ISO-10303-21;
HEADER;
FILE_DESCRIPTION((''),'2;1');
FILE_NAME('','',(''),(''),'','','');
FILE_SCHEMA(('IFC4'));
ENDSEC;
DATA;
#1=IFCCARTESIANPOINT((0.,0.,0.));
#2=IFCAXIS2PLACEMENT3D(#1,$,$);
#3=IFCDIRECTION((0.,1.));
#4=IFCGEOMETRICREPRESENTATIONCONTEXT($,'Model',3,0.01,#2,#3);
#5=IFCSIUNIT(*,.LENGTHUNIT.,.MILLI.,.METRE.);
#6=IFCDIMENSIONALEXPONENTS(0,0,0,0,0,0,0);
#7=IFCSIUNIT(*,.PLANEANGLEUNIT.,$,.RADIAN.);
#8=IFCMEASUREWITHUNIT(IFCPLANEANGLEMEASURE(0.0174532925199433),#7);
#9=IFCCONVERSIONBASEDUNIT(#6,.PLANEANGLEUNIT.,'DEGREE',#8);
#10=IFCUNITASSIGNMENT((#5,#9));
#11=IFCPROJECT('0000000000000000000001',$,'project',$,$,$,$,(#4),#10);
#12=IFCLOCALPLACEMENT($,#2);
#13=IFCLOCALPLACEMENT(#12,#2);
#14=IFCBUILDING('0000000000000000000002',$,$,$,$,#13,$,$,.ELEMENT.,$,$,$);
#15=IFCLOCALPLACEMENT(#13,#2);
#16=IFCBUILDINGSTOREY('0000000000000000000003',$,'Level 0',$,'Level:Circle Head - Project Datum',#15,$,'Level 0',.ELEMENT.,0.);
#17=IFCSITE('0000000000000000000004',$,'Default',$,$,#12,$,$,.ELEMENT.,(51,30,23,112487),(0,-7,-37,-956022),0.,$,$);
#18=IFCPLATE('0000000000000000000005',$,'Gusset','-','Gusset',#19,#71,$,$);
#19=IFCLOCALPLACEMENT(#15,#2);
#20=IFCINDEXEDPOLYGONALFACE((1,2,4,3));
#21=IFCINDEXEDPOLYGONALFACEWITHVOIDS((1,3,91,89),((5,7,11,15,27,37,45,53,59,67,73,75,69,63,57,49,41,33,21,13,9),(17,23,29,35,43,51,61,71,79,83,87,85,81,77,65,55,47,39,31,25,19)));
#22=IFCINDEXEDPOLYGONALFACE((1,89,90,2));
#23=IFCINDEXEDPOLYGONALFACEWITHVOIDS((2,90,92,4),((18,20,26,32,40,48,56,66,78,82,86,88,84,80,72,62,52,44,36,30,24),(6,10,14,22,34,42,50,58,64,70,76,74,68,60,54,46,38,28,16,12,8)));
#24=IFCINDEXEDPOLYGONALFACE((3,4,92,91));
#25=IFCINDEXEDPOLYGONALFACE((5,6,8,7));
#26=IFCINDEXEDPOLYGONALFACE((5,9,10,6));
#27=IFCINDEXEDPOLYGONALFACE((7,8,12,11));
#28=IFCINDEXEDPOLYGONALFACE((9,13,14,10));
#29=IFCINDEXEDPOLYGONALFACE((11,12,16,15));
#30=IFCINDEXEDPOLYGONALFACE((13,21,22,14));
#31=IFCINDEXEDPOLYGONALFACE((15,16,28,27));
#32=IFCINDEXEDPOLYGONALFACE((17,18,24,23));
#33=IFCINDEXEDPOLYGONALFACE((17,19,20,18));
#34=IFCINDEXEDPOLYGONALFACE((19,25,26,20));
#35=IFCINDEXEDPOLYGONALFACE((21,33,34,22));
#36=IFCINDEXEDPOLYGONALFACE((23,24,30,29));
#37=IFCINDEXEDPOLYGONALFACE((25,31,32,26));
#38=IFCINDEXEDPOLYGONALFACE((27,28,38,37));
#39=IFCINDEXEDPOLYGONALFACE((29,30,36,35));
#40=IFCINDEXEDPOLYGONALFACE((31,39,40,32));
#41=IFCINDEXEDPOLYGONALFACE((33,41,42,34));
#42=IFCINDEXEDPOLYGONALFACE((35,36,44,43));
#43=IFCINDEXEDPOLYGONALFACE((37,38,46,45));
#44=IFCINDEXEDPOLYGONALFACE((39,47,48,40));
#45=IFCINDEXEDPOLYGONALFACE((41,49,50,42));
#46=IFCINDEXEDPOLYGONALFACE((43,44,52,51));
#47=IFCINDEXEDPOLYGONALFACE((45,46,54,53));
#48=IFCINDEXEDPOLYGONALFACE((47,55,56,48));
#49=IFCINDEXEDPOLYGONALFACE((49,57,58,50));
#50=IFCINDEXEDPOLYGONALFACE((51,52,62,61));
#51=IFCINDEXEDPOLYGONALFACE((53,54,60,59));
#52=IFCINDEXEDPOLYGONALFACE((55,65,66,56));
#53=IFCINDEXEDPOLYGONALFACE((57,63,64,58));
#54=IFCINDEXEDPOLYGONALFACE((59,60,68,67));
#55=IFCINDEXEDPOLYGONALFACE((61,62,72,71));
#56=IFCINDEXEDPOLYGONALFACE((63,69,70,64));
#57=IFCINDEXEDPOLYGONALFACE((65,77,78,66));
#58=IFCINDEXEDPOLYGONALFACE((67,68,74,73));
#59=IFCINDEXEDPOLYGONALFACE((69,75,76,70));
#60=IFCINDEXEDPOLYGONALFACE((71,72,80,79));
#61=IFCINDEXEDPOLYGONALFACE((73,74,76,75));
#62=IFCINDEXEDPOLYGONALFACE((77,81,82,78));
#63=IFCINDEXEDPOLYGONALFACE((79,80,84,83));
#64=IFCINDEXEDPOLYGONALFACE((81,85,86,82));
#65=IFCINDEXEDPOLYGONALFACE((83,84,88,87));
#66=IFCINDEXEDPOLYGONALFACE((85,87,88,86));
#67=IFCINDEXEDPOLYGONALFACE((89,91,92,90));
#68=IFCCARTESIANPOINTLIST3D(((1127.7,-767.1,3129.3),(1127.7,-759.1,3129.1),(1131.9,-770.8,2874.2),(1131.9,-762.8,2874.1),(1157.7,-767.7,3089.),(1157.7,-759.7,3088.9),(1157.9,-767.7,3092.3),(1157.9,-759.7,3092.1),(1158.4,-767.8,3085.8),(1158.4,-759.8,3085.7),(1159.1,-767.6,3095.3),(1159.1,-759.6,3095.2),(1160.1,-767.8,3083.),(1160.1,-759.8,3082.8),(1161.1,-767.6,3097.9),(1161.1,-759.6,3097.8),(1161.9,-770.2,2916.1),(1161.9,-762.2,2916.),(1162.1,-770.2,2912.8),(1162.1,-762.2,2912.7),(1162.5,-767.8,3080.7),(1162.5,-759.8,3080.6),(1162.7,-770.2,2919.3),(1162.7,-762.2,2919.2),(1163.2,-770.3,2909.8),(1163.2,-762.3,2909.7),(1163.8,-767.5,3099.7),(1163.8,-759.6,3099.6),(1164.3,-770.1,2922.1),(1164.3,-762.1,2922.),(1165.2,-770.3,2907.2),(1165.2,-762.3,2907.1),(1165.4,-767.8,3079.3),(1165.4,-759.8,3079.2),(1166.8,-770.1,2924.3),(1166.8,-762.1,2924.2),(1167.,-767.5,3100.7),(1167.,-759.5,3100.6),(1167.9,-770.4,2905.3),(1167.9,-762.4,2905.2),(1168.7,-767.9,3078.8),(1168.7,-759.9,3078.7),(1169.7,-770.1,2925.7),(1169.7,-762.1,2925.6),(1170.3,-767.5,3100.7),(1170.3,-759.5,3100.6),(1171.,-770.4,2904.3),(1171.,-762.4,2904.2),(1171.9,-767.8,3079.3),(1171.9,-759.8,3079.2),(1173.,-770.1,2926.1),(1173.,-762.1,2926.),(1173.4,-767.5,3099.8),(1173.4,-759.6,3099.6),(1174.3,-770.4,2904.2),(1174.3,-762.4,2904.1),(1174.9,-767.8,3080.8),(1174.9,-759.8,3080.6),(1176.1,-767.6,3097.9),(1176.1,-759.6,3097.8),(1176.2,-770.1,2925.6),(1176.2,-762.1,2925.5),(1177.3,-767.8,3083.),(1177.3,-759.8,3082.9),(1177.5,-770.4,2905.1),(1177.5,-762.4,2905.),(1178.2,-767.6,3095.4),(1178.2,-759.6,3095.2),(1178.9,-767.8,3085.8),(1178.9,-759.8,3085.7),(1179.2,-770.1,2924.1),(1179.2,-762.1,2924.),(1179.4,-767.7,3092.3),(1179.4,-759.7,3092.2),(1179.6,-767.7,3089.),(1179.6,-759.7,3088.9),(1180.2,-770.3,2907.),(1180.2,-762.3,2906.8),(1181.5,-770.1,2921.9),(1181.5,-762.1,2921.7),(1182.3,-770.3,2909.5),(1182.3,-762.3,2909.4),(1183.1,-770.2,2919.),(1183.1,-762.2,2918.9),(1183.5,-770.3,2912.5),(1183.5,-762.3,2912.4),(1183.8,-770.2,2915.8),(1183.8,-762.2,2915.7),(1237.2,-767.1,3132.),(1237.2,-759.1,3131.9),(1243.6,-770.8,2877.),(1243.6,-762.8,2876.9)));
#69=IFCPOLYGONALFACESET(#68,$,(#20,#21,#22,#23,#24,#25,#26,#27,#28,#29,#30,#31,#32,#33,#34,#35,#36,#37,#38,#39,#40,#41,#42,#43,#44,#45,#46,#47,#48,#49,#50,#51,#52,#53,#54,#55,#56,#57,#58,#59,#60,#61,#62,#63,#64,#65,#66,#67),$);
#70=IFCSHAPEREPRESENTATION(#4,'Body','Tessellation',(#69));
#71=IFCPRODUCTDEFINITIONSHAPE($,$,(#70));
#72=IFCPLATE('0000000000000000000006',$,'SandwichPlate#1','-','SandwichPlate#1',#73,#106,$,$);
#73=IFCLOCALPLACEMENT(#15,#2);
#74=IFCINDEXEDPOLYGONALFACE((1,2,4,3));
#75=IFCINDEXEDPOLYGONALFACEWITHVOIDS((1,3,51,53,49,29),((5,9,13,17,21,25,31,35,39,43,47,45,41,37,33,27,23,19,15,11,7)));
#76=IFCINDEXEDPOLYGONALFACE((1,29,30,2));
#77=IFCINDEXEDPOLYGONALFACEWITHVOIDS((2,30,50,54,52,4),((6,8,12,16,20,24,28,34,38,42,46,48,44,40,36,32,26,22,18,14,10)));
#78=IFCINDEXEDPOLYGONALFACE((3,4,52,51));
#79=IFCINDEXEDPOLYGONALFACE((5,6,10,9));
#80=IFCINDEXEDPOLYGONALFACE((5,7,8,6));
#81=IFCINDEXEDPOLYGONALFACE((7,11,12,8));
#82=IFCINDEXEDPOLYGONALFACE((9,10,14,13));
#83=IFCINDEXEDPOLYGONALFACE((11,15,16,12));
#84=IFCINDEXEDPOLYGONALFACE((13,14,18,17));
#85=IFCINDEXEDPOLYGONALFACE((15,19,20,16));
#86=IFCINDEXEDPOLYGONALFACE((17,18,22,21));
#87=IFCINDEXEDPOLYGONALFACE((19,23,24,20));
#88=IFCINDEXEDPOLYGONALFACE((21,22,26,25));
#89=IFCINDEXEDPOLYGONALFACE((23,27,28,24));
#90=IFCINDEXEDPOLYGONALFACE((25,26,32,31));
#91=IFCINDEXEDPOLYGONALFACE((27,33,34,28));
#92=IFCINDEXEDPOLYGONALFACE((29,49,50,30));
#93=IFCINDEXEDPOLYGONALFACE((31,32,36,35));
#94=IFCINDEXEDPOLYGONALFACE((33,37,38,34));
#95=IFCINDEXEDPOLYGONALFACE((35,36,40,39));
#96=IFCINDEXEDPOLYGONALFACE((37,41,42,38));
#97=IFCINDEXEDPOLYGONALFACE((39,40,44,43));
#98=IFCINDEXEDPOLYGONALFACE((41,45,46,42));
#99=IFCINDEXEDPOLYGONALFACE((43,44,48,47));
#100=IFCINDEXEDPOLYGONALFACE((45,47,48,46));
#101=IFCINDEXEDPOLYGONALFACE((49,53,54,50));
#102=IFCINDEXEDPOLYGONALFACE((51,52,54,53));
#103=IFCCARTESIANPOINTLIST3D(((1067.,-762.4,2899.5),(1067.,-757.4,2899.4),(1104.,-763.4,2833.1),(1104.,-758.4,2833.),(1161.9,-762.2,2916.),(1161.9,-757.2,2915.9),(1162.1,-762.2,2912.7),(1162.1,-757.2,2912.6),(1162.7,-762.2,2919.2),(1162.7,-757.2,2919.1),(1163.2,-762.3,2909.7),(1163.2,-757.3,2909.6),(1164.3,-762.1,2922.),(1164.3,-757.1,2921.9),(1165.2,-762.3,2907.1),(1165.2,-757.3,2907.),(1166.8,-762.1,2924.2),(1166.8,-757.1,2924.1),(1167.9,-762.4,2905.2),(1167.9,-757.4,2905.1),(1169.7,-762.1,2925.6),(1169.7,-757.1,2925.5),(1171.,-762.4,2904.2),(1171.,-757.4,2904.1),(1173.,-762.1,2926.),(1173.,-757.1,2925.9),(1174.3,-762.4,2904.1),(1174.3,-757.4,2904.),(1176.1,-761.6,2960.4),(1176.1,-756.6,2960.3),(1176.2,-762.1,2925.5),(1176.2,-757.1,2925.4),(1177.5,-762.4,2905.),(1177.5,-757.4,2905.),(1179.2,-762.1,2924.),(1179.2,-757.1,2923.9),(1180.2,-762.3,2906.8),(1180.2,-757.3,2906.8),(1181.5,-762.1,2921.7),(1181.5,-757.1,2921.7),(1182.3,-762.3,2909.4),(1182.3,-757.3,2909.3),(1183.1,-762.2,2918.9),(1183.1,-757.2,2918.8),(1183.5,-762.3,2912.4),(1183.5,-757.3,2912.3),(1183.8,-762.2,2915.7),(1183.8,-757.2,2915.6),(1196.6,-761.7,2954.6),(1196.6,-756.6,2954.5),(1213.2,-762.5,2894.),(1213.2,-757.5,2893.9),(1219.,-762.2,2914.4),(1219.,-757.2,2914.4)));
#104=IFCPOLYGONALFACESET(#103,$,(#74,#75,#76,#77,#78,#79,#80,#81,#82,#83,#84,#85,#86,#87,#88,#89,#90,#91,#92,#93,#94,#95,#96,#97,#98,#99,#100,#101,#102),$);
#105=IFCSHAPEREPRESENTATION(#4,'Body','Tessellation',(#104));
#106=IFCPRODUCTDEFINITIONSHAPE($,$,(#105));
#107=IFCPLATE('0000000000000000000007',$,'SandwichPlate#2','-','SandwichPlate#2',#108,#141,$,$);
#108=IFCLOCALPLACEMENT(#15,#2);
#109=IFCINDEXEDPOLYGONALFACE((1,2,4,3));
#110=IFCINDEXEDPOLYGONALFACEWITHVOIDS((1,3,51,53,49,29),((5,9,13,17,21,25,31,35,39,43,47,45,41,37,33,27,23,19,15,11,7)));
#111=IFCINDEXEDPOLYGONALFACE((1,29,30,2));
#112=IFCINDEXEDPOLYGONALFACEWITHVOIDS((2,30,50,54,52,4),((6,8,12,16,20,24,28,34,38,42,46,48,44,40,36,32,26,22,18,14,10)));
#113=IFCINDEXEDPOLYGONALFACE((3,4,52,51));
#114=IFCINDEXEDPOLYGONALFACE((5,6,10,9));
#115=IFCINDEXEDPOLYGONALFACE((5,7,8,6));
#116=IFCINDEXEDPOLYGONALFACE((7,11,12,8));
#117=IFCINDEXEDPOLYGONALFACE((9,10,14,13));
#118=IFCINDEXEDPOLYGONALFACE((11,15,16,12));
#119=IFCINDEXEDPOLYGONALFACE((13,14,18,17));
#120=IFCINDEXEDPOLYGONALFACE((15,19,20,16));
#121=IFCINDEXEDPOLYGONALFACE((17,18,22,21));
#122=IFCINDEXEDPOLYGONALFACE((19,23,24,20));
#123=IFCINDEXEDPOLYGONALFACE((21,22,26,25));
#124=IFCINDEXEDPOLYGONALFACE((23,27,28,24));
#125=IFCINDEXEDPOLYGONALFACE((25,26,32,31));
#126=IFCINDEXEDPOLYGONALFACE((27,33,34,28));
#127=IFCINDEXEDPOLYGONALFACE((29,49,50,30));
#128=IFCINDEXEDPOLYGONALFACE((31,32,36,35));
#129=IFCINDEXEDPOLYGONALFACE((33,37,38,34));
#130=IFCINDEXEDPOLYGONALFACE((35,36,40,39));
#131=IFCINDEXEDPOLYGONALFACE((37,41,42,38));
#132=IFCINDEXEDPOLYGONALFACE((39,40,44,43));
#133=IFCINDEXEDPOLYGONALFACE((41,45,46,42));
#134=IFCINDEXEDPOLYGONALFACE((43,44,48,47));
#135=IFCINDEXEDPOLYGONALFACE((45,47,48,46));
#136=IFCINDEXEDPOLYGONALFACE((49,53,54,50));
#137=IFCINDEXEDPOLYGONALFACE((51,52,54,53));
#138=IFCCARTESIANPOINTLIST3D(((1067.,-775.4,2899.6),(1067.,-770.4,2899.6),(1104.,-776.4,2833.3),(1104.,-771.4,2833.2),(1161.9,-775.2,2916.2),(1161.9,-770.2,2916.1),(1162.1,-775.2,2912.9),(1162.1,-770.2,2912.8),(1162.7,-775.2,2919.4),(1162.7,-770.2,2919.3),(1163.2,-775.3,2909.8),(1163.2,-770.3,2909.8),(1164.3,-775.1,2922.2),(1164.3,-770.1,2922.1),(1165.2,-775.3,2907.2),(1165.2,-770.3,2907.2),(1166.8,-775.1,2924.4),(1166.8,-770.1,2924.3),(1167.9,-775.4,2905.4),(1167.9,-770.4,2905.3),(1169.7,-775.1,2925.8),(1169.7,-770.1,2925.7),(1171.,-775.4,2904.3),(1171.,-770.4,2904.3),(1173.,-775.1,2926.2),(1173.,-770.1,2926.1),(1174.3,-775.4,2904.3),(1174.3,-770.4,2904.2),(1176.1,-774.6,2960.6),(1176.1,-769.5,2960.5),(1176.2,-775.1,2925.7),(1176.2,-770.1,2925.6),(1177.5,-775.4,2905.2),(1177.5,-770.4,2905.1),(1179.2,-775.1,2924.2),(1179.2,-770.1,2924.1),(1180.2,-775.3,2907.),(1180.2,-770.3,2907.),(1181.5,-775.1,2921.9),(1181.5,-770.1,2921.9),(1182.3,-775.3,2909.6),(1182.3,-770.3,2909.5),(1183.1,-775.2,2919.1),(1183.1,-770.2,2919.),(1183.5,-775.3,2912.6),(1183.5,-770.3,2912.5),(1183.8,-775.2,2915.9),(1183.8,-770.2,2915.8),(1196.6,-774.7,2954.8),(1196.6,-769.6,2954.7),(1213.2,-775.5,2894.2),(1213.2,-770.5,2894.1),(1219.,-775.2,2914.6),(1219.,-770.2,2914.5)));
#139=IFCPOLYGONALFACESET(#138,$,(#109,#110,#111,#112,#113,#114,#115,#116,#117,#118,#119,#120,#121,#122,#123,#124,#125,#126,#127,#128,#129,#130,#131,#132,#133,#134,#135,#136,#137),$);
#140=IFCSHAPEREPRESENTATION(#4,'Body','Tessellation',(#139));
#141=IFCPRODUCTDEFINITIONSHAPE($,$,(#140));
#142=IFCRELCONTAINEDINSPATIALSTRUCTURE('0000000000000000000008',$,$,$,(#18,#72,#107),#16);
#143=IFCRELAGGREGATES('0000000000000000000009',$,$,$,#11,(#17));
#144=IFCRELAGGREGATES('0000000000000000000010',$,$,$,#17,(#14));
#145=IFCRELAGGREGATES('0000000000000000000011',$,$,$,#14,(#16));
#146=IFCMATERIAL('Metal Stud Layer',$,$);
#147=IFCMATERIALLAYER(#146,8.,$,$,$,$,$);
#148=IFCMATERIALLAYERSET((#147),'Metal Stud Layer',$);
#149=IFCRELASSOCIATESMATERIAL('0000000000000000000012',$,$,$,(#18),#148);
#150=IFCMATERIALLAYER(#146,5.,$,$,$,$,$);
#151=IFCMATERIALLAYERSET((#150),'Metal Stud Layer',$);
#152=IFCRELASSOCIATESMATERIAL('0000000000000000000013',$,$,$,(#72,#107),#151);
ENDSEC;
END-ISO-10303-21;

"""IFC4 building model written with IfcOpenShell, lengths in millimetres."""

from ifc_helpers import new_model, entity, si_unit, converted_unit, direction, frame, origin, origin_with_axes, origin_2d_with_axis, place, context, project, spatial, polyline, circle, outline, extrude, material, layer, layer_set, element, save


model = new_model("IFC4")

# Units and contexts
model_context = context("Model", 3, precision=0.01, world=origin(), true_north=direction((0.0, 1.0)))
ifc_project = project(units=[si_unit("LENGTHUNIT", "METRE", prefix="MILLI"), converted_unit("PLANEANGLEUNIT", "DEGREE", entity("IfcPlaneAngleMeasure", 0.0174532925199433), si_unit("PLANEANGLEUNIT", "RADIAN"), dimensions=[0, 0, 0, 0, 0, 0, 0])], contexts=[model_context])

# Site, building, storey
site_placement = place(None, origin())
site = spatial("IfcSite", under=ifc_project, at=site_placement, Name="Default", CompositionType="ELEMENT", RefLatitude=(51, 30, 23, 112487), RefLongitude=(0, -7, -37, -956022), RefElevation=0.0)
building_placement = place(site_placement, origin())
building = spatial("IfcBuilding", under=site, at=building_placement, CompositionType="ELEMENT")
storey_placement = place(building_placement, origin())
storey = spatial("IfcBuildingStorey", under=building, at=storey_placement, Name="Level 0", ObjectType="Level:Circle Head - Project Datum", LongName="Level 0", CompositionType="ELEMENT", Elevation=0.0)

# Plates, openings
ifc_material = material(Name="Metal Stud Layer")
ifc_layer_1 = layer(ifc_material, 8.0)
ifc_layer_set_1 = layer_set([ifc_layer_1], Name="Metal Stud Layer")
plate_1_placement = place(storey_placement, frame((1235.2, -767.1, 3131.9), z_axis=(0.0, 0.999896, -0.014432), x_axis=(0.02499, -0.014428, -0.999584)))
plate_1 = element("IfcPlate", 1, at=plate_1_placement, inside=storey, material=ifc_layer_set_1, Name="Gusset", Description="-", ObjectType="Gusset", context=model_context, shape_type="SweptSolid", body=[
    extrude(outline(polyline([(0.0, -2.0), (255.1, -2.0), (255.1, 109.7), (0.0, 107.5), (0.0, -2.0)])), origin_with_axes(), (0.0, 0.0, 1.0), 8.0),
])
opening_1_placement = place(plate_1_placement, frame((40.4, 67.6, 8.5), z_axis=(0.0, 0.0, -1.0), x_axis=(-0.51948, 0.854483, 0.0)))
element("IfcOpeningElement", 2, at=opening_1_placement, cuts=plate_1, ObjectType="Opening", context=model_context, shape_type="SweptSolid", body=[
    extrude(circle(Radius=11.0, at=origin_2d_with_axis()), origin(), (0.0, 0.0, 1.0), 9.0),
])
opening_2_placement = place(plate_1_placement, frame((215.2, 67.8, 8.5), z_axis=(0.0, 0.0, -1.0), x_axis=(0.465432, 0.885083, 0.0)))
element("IfcOpeningElement", 3, at=opening_2_placement, cuts=plate_1, ObjectType="Opening", context=model_context, shape_type="SweptSolid", body=[
    extrude(circle(Radius=11.0, at=origin_2d_with_axis()), origin(), (0.0, 0.0, 1.0), 9.0),
])
ifc_layer_2 = layer(ifc_material, 5.0)
ifc_layer_set_2 = layer_set([ifc_layer_2], Name="Metal Stud Layer")
plate_2_placement = place(storey_placement, frame((1226.3, -757.4, 2901.3), z_axis=(0.0, -0.999896, 0.014432), x_axis=(-0.487405, 0.012602, 0.873085)))
plate_2 = element("IfcPlate", 4, at=plate_2_placement, inside=storey, material=ifc_layer_set_2, Name="SandwichPlate#1", Description="-", ObjectType="SandwichPlate#1", context=model_context, shape_type="SweptSolid", body=[
    extrude(outline(polyline([(0.0, 0.0), (76.0, 0.0), (76.0, 140.0), (0.0, 140.0), (0.0, 0.0)])), origin_with_axes(), (0.0, 0.0, 1.0), 5.0),
])
opening_3_placement = place(plate_2_placement, frame((0.0, 0.0, 0.0), z_axis=(0.0, 0.0, 1.0), x_axis=(1.0, 0.0, 0.0)))
element("IfcOpeningElement", 5, at=opening_3_placement, cuts=plate_2, ObjectType="Opening", context=model_context, shape_type="SweptSolid", body=[
    extrude(outline(polyline([(0.0, 0.0), (15.0, 0.0), (0.0, 15.0), (0.0, 0.0)])), origin(), (0.0, 0.0, 1.0), 5.0),
])
opening_4_placement = place(plate_2_placement, frame((0.0, 0.0, 0.0), z_axis=(0.0, 0.0, 1.0), x_axis=(1.0, 0.0, 0.0)))
element("IfcOpeningElement", 6, at=opening_4_placement, cuts=plate_2, ObjectType="Opening", context=model_context, shape_type="SweptSolid", body=[
    extrude(outline(polyline([(76.0, 0.0), (76.0, 15.0), (61.0, 0.0), (76.0, 0.0)])), origin(), (0.0, 0.0, 1.0), 5.0),
])
opening_5_placement = place(plate_2_placement, frame((38.0, 40.0, -0.5), z_axis=(0.0, 0.0, 1.0), x_axis=(0.0, 1.0, 0.0)))
element("IfcOpeningElement", 7, at=opening_5_placement, cuts=plate_2, ObjectType="Opening", context=model_context, shape_type="SweptSolid", body=[
    extrude(circle(Radius=11.0, at=origin_2d_with_axis()), origin(), (0.0, 0.0, 1.0), 6.0),
])
plate_3_placement = place(storey_placement, frame((1226.3, -770.4, 2901.4), z_axis=(0.0, -0.999896, 0.014432), x_axis=(-0.487405, 0.012602, 0.873085)))
plate_3 = element("IfcPlate", 8, at=plate_3_placement, inside=storey, material=ifc_layer_set_2, Name="SandwichPlate#2", Description="-", ObjectType="SandwichPlate#2", context=model_context, shape_type="SweptSolid", body=[
    extrude(outline(polyline([(0.0, 0.0), (76.0, 0.0), (76.0, 140.0), (0.0, 140.0), (0.0, 0.0)])), origin_with_axes(), (0.0, 0.0, 1.0), 5.0),
])
opening_6_placement = place(plate_3_placement, frame((0.0, 0.0, 0.0), z_axis=(0.0, 0.0, 1.0), x_axis=(1.0, 0.0, 0.0)))
element("IfcOpeningElement", 9, at=opening_6_placement, cuts=plate_3, ObjectType="Opening", context=model_context, shape_type="SweptSolid", body=[
    extrude(outline(polyline([(0.0, 0.0), (15.0, 0.0), (0.0, 15.0), (0.0, 0.0)])), origin(), (0.0, 0.0, 1.0), 5.0),
])
opening_7_placement = place(plate_3_placement, frame((0.0, 0.0, 0.0), z_axis=(0.0, 0.0, 1.0), x_axis=(1.0, 0.0, 0.0)))
element("IfcOpeningElement", 10, at=opening_7_placement, cuts=plate_3, ObjectType="Opening", context=model_context, shape_type="SweptSolid", body=[
    extrude(outline(polyline([(76.0, 0.0), (76.0, 15.0), (61.0, 0.0), (76.0, 0.0)])), origin(), (0.0, 0.0, 1.0), 5.0),
])
opening_8_placement = place(plate_3_placement, frame((38.0, 40.0, -0.5), z_axis=(0.0, 0.0, 1.0), x_axis=(0.0, 1.0, 0.0)))
element("IfcOpeningElement", 11, at=opening_8_placement, cuts=plate_3, ObjectType="Opening", context=model_context, shape_type="SweptSolid", body=[
    extrude(circle(Radius=11.0, at=origin_2d_with_axis()), origin(), (0.0, 0.0, 1.0), 6.0),
])

save(model, "model.ifc")
